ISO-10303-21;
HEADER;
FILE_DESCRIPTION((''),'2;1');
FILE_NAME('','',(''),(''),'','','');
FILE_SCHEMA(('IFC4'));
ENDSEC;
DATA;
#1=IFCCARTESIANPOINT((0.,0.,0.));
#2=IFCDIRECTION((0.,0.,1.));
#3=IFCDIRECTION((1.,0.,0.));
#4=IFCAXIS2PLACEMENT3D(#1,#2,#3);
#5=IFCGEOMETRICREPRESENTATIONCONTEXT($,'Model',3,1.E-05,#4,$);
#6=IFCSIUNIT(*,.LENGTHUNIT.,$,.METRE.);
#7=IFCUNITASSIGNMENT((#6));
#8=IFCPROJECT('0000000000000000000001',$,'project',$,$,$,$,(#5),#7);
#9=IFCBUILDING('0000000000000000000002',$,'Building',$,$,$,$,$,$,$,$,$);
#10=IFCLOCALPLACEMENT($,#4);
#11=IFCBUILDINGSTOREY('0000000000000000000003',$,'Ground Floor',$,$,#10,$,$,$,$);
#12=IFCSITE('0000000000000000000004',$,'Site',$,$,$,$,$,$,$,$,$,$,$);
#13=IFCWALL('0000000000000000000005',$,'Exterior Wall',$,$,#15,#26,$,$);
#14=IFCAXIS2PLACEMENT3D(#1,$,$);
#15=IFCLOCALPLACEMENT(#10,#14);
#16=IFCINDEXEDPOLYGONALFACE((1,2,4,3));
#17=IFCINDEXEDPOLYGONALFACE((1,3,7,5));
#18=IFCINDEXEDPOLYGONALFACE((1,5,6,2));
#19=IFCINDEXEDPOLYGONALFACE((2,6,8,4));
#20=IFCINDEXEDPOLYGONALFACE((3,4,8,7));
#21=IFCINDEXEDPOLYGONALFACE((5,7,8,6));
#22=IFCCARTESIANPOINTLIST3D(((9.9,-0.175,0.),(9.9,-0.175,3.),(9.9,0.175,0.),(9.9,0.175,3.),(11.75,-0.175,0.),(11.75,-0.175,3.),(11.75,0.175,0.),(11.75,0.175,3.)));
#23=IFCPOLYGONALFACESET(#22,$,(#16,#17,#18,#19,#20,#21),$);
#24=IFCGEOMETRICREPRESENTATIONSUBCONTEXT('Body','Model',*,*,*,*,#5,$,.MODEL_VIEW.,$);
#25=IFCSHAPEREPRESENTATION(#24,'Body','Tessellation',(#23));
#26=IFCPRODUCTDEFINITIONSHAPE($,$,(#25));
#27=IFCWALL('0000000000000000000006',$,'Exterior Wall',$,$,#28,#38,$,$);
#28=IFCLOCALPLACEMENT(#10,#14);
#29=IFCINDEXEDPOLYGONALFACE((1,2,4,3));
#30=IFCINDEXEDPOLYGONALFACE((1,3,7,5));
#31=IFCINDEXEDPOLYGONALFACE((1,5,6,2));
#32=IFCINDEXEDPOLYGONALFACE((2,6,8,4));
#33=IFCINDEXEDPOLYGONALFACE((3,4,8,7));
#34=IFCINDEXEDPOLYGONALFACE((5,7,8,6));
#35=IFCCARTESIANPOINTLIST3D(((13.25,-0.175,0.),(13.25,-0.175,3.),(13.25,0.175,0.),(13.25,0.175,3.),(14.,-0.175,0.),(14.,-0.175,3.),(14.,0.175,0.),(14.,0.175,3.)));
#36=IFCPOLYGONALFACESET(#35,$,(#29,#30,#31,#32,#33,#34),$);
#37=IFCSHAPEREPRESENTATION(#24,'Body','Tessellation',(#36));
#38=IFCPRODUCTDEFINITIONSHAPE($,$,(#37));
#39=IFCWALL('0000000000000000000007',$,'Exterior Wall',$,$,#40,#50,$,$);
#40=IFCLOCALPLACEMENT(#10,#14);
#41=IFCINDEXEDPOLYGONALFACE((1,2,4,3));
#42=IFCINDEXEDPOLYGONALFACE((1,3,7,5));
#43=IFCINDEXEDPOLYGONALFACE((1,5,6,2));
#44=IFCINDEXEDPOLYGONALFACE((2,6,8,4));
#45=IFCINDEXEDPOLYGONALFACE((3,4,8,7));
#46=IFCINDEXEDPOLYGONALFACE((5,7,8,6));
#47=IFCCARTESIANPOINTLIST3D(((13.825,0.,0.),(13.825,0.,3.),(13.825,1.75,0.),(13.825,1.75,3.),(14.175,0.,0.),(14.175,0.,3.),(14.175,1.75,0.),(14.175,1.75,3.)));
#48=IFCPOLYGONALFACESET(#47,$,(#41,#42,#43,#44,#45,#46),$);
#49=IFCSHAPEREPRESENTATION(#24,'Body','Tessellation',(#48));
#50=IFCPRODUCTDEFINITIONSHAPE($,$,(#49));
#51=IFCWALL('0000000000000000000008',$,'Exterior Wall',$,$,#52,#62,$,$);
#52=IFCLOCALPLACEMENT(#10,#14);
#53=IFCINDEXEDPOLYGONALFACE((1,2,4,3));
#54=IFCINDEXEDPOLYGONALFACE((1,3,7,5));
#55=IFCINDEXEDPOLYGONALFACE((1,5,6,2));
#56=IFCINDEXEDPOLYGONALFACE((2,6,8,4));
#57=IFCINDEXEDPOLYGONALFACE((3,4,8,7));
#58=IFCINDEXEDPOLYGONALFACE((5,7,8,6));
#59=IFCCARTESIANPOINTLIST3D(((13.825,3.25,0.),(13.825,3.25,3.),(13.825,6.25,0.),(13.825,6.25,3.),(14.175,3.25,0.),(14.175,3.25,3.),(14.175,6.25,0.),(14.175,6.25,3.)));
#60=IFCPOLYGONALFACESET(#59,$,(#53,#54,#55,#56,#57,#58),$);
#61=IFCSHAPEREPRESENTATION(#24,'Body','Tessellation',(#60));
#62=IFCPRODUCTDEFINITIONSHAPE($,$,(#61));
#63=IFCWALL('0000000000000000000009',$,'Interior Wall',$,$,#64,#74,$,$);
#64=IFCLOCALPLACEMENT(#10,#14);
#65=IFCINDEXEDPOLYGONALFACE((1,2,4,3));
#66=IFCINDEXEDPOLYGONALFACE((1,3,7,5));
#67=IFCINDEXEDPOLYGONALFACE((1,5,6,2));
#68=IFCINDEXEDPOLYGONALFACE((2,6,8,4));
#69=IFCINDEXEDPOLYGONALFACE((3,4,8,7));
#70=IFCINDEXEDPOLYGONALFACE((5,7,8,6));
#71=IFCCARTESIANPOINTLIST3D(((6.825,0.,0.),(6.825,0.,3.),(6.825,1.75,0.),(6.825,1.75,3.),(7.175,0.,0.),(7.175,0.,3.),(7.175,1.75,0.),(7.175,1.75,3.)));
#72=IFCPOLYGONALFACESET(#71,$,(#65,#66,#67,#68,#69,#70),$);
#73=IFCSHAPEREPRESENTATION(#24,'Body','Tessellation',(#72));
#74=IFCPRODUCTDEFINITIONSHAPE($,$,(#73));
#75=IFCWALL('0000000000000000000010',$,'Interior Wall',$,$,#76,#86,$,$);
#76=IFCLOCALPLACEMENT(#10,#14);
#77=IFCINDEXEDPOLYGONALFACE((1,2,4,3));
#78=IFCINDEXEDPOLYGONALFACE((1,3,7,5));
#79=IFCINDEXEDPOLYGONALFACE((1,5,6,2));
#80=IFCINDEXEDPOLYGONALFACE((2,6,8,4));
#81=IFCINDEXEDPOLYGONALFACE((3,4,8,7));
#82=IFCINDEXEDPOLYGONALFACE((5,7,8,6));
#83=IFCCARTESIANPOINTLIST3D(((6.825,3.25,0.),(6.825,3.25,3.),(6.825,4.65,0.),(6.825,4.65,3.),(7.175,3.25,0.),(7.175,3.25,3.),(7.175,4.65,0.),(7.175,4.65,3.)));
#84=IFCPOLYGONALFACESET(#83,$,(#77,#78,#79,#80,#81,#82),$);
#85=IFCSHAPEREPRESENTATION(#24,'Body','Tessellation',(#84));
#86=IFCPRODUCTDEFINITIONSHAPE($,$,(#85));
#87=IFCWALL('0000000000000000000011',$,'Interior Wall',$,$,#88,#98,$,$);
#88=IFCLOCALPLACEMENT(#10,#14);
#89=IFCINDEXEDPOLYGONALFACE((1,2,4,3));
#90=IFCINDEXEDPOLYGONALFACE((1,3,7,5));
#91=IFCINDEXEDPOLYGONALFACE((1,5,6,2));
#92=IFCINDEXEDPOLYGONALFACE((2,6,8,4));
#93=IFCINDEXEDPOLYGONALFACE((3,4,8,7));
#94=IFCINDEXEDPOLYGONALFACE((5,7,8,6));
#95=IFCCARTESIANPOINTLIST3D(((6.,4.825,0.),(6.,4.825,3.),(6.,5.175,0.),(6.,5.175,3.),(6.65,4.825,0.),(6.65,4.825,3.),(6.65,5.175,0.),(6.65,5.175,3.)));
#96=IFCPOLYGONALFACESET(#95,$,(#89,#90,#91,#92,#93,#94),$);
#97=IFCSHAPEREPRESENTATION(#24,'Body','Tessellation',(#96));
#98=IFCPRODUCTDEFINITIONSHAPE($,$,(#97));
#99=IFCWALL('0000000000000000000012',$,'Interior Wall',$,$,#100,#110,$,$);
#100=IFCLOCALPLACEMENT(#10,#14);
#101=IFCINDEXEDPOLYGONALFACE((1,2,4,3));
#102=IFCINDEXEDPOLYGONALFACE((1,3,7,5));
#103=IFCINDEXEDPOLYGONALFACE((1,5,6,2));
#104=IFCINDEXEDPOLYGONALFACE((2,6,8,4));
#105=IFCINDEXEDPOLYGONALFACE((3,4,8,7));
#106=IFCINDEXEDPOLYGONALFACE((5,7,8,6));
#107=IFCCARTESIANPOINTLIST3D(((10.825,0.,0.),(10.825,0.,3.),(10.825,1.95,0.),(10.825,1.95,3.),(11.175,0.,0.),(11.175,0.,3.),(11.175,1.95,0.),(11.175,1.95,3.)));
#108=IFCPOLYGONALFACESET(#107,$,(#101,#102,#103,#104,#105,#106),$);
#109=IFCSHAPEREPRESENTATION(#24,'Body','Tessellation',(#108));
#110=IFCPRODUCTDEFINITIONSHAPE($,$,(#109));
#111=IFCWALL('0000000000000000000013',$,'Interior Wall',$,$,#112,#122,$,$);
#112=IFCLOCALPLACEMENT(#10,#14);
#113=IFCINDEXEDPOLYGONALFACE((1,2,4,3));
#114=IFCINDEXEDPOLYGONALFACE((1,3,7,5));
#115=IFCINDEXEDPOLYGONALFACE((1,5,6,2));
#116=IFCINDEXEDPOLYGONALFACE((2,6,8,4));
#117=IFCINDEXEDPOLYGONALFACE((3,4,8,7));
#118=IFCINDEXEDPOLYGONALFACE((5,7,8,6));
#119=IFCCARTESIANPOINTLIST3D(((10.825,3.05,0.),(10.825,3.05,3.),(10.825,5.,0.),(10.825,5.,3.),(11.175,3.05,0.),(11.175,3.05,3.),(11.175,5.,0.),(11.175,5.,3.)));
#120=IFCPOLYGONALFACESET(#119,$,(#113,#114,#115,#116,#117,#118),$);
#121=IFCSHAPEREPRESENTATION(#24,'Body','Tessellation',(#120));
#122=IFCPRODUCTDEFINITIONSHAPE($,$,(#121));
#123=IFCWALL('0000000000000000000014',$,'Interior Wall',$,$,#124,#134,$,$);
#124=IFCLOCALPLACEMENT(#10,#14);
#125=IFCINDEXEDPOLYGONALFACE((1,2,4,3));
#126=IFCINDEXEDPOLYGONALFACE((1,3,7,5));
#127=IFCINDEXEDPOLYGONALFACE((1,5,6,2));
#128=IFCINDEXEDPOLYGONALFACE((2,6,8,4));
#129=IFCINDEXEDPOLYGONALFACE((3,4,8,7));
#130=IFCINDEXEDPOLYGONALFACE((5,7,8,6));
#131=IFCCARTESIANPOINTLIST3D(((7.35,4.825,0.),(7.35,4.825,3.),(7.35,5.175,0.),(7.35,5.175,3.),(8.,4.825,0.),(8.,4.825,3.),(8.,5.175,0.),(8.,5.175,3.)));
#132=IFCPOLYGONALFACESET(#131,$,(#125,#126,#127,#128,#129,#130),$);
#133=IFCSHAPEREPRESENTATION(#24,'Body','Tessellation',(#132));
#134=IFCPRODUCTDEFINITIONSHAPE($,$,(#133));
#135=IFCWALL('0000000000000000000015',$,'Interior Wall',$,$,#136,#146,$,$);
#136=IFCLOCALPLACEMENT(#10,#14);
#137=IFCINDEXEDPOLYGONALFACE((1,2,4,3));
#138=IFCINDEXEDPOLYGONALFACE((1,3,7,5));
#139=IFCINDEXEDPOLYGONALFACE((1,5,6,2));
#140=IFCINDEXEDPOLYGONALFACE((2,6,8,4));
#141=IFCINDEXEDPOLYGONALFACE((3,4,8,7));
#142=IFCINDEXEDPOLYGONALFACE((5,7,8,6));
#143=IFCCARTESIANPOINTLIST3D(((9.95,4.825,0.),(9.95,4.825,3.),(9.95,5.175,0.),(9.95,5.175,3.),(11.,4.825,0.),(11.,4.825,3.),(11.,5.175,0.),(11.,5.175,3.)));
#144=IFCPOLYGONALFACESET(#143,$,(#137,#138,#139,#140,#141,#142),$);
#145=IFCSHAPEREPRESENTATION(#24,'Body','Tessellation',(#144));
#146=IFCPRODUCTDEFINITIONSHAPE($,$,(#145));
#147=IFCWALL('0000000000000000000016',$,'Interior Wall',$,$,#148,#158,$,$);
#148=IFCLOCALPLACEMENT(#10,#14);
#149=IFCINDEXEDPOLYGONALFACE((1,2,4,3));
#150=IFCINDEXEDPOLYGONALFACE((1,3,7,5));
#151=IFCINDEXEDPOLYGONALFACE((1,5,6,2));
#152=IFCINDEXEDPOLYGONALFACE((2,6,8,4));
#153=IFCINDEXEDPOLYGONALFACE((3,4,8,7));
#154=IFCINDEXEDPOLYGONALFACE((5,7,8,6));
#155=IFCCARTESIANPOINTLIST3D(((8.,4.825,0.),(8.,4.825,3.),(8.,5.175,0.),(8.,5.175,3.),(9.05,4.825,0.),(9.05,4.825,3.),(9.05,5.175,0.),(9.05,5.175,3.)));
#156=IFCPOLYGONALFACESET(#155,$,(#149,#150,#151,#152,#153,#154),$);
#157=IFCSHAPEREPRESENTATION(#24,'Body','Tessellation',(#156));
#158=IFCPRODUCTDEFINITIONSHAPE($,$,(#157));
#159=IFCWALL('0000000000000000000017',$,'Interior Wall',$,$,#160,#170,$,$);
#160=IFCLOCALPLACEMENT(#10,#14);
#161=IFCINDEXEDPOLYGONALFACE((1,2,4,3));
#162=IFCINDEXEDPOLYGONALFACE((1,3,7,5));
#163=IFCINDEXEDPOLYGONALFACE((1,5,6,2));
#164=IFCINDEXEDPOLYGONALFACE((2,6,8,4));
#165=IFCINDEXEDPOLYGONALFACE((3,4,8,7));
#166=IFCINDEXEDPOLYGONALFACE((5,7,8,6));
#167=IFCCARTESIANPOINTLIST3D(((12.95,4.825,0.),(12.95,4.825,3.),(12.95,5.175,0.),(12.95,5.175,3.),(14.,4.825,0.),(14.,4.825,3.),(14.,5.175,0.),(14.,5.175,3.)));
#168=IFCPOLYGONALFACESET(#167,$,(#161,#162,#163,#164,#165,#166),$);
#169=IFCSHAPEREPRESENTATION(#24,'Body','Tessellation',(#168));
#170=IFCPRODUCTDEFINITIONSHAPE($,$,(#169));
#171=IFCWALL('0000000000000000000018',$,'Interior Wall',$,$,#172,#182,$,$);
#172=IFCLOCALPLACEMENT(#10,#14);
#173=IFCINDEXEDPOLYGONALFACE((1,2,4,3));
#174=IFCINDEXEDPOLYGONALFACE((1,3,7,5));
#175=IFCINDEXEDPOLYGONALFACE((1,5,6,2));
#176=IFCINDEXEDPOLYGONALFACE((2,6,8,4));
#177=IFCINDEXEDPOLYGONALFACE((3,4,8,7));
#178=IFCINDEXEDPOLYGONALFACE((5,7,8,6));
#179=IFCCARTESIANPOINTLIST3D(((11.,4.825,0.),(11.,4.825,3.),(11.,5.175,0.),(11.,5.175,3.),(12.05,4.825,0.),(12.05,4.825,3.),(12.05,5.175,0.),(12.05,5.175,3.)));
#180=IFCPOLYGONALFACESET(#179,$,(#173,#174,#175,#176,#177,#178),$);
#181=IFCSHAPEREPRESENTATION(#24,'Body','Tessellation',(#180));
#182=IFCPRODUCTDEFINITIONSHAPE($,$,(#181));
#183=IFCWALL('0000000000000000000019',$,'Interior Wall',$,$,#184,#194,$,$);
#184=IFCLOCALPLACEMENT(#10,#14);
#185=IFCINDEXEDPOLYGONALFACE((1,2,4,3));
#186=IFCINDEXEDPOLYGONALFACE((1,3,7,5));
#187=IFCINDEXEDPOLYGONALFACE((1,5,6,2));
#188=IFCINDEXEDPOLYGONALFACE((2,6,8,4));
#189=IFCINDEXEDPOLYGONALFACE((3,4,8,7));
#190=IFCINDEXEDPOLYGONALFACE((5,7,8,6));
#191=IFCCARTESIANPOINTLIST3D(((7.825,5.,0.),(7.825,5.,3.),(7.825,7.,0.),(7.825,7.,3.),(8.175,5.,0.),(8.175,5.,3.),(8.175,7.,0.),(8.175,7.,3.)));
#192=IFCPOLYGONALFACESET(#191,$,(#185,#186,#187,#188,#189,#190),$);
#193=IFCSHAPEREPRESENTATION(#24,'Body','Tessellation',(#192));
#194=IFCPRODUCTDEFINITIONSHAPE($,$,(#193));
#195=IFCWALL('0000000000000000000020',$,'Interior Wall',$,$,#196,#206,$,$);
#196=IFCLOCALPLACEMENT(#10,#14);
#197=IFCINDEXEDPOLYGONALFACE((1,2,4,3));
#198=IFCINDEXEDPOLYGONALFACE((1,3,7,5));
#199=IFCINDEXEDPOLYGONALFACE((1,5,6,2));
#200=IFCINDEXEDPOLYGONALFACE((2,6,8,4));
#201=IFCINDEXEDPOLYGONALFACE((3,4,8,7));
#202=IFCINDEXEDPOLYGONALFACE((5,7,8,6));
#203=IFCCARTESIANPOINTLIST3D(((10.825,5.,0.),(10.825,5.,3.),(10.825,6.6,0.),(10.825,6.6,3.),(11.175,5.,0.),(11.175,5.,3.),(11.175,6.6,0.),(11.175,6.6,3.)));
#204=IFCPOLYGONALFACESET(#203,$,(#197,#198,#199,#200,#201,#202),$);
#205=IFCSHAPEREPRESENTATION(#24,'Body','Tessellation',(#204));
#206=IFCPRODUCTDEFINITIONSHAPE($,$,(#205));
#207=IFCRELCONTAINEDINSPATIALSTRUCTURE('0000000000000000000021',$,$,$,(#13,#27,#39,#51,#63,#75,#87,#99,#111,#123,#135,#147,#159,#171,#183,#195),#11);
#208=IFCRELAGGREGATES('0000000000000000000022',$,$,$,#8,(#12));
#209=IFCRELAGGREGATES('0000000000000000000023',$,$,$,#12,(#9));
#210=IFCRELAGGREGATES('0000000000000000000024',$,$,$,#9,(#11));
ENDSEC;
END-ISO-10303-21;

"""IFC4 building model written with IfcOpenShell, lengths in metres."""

from ifc_helpers import new_model, si_unit, frame, origin_with_axes, place, context, subcontext, project, spatial, indexed_curve, outline, extrude, element, save


model = new_model("IFC4")

# Units and contexts
model_context = context("Model", 3, precision=1e-05, world=origin_with_axes())
body_context = subcontext(model_context, "Body", "Model", "MODEL_VIEW")
ifc_project = project(units=[si_unit("LENGTHUNIT", "METRE")], contexts=[model_context])

# Site, building, storey
site = spatial("IfcSite", under=ifc_project, Name="Site")
building = spatial("IfcBuilding", under=site, Name="Building")
storey_placement = place(None, origin_with_axes())
storey = spatial("IfcBuildingStorey", under=building, at=storey_placement, Name="Ground Floor")

# Walls
wall_1_placement = place(storey_placement, frame((9.9, 0.0, 0.0), z_axis=(0.0, 0.0, 1.0), x_axis=(1.0, 0.0, 0.0)))
element("IfcWall", 1, at=wall_1_placement, inside=storey, Name="Exterior Wall", context=body_context, shape_type="SweptSolid", body=[
    extrude(outline(indexed_curve([(0.0, 0.0), (0.0, 0.35), (1.85, 0.35), (1.85, 0.0), (0.0, 0.0)], self_intersect=False)), frame((0.0, -0.175, 0.0), z_axis=(0.0, 0.0, 1.0), x_axis=(1.0, 0.0, 0.0)), (0.0, 0.0, 1.0), 3.0),
])
wall_2_placement = place(storey_placement, frame((13.25, 0.0, 0.0), z_axis=(0.0, 0.0, 1.0), x_axis=(1.0, 0.0, 0.0)))
element("IfcWall", 2, at=wall_2_placement, inside=storey, Name="Exterior Wall", context=body_context, shape_type="SweptSolid", body=[
    extrude(outline(indexed_curve([(0.0, 0.0), (0.0, 0.35), (0.75, 0.35), (0.75, 0.0), (0.0, 0.0)], self_intersect=False)), frame((0.0, -0.175, 0.0), z_axis=(0.0, 0.0, 1.0), x_axis=(1.0, 0.0, 0.0)), (0.0, 0.0, 1.0), 3.0),
])
wall_3_placement = place(storey_placement, frame((14.0, 0.0, 0.0), z_axis=(0.0, 0.0, 1.0), x_axis=(0.0, 1.0, 0.0)))
element("IfcWall", 3, at=wall_3_placement, inside=storey, Name="Exterior Wall", context=body_context, shape_type="SweptSolid", body=[
    extrude(outline(indexed_curve([(0.0, 0.0), (0.0, 0.35), (1.75, 0.35), (1.75, 0.0), (0.0, 0.0)], self_intersect=False)), frame((0.0, -0.175, 0.0), z_axis=(0.0, 0.0, 1.0), x_axis=(1.0, 0.0, 0.0)), (0.0, 0.0, 1.0), 3.0),
])
wall_4_placement = place(storey_placement, frame((14.0, 3.25, 0.0), z_axis=(0.0, 0.0, 1.0), x_axis=(0.0, 1.0, 0.0)))
element("IfcWall", 4, at=wall_4_placement, inside=storey, Name="Exterior Wall", context=body_context, shape_type="SweptSolid", body=[
    extrude(outline(indexed_curve([(0.0, 0.0), (0.0, 0.35), (3.0, 0.35), (3.0, 0.0), (0.0, 0.0)], self_intersect=False)), frame((0.0, -0.175, 0.0), z_axis=(0.0, 0.0, 1.0), x_axis=(1.0, 0.0, 0.0)), (0.0, 0.0, 1.0), 3.0),
])
wall_5_placement = place(storey_placement, frame((7.0, 0.0, 0.0), z_axis=(0.0, 0.0, 1.0), x_axis=(0.0, 1.0, 0.0)))
element("IfcWall", 5, at=wall_5_placement, inside=storey, Name="Interior Wall", context=body_context, shape_type="SweptSolid", body=[
    extrude(outline(indexed_curve([(0.0, 0.0), (0.0, 0.35), (1.75, 0.35), (1.75, 0.0), (0.0, 0.0)], self_intersect=False)), frame((0.0, -0.175, 0.0), z_axis=(0.0, 0.0, 1.0), x_axis=(1.0, 0.0, 0.0)), (0.0, 0.0, 1.0), 3.0),
])
wall_6_placement = place(storey_placement, frame((7.0, 3.25, 0.0), z_axis=(0.0, 0.0, 1.0), x_axis=(0.0, 1.0, 0.0)))
element("IfcWall", 6, at=wall_6_placement, inside=storey, Name="Interior Wall", context=body_context, shape_type="SweptSolid", body=[
    extrude(outline(indexed_curve([(0.0, 0.0), (0.0, 0.35), (1.4, 0.35), (1.4, 0.0), (0.0, 0.0)], self_intersect=False)), frame((0.0, -0.175, 0.0), z_axis=(0.0, 0.0, 1.0), x_axis=(1.0, 0.0, 0.0)), (0.0, 0.0, 1.0), 3.0),
])
wall_7_placement = place(storey_placement, frame((6.65, 5.0, 0.0), z_axis=(0.0, 0.0, 1.0), x_axis=(-1.0, 0.0, 0.0)))
element("IfcWall", 7, at=wall_7_placement, inside=storey, Name="Interior Wall", context=body_context, shape_type="SweptSolid", body=[
    extrude(outline(indexed_curve([(0.0, 0.0), (0.0, 0.35), (0.65, 0.35), (0.65, 0.0), (0.0, 0.0)], self_intersect=False)), frame((0.0, -0.175, 0.0), z_axis=(0.0, 0.0, 1.0), x_axis=(1.0, 0.0, 0.0)), (0.0, 0.0, 1.0), 3.0),
])
wall_8_placement = place(storey_placement, frame((11.0, 0.0, 0.0), z_axis=(0.0, 0.0, 1.0), x_axis=(0.0, 1.0, 0.0)))
element("IfcWall", 8, at=wall_8_placement, inside=storey, Name="Interior Wall", context=body_context, shape_type="SweptSolid", body=[
    extrude(outline(indexed_curve([(0.0, 0.0), (0.0, 0.35), (1.95, 0.35), (1.95, 0.0), (0.0, 0.0)], self_intersect=False)), frame((0.0, -0.175, 0.0), z_axis=(0.0, 0.0, 1.0), x_axis=(1.0, 0.0, 0.0)), (0.0, 0.0, 1.0), 3.0),
])
wall_9_placement = place(storey_placement, frame((11.0, 3.05, 0.0), z_axis=(0.0, 0.0, 1.0), x_axis=(0.0, 1.0, 0.0)))
element("IfcWall", 9, at=wall_9_placement, inside=storey, Name="Interior Wall", context=body_context, shape_type="SweptSolid", body=[
    extrude(outline(indexed_curve([(0.0, 0.0), (0.0, 0.35), (1.95, 0.35), (1.95, 0.0), (0.0, 0.0)], self_intersect=False)), frame((0.0, -0.175, 0.0), z_axis=(0.0, 0.0, 1.0), x_axis=(1.0, 0.0, 0.0)), (0.0, 0.0, 1.0), 3.0),
])
wall_10_placement = place(storey_placement, frame((8.0, 5.0, 0.0), z_axis=(0.0, 0.0, 1.0), x_axis=(-1.0, 0.0, 0.0)))
element("IfcWall", 10, at=wall_10_placement, inside=storey, Name="Interior Wall", context=body_context, shape_type="SweptSolid", body=[
    extrude(outline(indexed_curve([(0.0, 0.0), (0.0, 0.35), (0.65, 0.35), (0.65, 0.0), (0.0, 0.0)], self_intersect=False)), frame((0.0, -0.175, 0.0), z_axis=(0.0, 0.0, 1.0), x_axis=(1.0, 0.0, 0.0)), (0.0, 0.0, 1.0), 3.0),
])
for number, where, z_axis, x_axis, name in (
    (11, (11.0, 5.0, 0.0), (0.0, 0.0, 1.0), (-1.0, 0.0, 0.0), "Interior Wall"),
    (12, (9.05, 5.0, 0.0), (0.0, 0.0, 1.0), (-1.0, 0.0, 0.0), "Interior Wall"),
    (13, (14.0, 5.0, 0.0), (0.0, 0.0, 1.0), (-1.0, 0.0, 0.0), "Interior Wall"),
    (14, (12.05, 5.0, 0.0), (0.0, 0.0, 1.0), (-1.0, 0.0, 0.0), "Interior Wall"),
):
    element("IfcWall", number, at=place(storey_placement, frame(where, z_axis=z_axis, x_axis=x_axis)), inside=storey, Name=name, context=body_context, shape_type="SweptSolid", body=[
        extrude(outline(indexed_curve([(0.0, 0.0), (0.0, 0.35), (1.05, 0.35), (1.05, 0.0), (0.0, 0.0)], self_intersect=False)), frame((0.0, -0.175, 0.0), z_axis=(0.0, 0.0, 1.0), x_axis=(1.0, 0.0, 0.0)), (0.0, 0.0, 1.0), 3.0),
    ])
wall_11_placement = place(storey_placement, frame((8.0, 5.0, 0.0), z_axis=(0.0, 0.0, 1.0), x_axis=(0.0, 1.0, 0.0)))
element("IfcWall", 15, at=wall_11_placement, inside=storey, Name="Interior Wall", context=body_context, shape_type="SweptSolid", body=[
    extrude(outline(indexed_curve([(0.0, 0.0), (0.0, 0.35), (2.0, 0.35), (2.0, 0.0), (0.0, 0.0)], self_intersect=False)), frame((0.0, -0.175, 0.0), z_axis=(0.0, 0.0, 1.0), x_axis=(1.0, 0.0, 0.0)), (0.0, 0.0, 1.0), 3.0),
])
wall_12_placement = place(storey_placement, frame((11.0, 5.0, 0.0), z_axis=(0.0, 0.0, 1.0), x_axis=(0.0, 1.0, 0.0)))
element("IfcWall", 16, at=wall_12_placement, inside=storey, Name="Interior Wall", context=body_context, shape_type="SweptSolid", body=[
    extrude(outline(indexed_curve([(0.0, 0.0), (0.0, 0.35), (1.6, 0.35), (1.6, 0.0), (0.0, 0.0)], self_intersect=False)), frame((0.0, -0.175, 0.0), z_axis=(0.0, 0.0, 1.0), x_axis=(1.0, 0.0, 0.0)), (0.0, 0.0, 1.0), 3.0),
])

save(model, "model.ifc")
